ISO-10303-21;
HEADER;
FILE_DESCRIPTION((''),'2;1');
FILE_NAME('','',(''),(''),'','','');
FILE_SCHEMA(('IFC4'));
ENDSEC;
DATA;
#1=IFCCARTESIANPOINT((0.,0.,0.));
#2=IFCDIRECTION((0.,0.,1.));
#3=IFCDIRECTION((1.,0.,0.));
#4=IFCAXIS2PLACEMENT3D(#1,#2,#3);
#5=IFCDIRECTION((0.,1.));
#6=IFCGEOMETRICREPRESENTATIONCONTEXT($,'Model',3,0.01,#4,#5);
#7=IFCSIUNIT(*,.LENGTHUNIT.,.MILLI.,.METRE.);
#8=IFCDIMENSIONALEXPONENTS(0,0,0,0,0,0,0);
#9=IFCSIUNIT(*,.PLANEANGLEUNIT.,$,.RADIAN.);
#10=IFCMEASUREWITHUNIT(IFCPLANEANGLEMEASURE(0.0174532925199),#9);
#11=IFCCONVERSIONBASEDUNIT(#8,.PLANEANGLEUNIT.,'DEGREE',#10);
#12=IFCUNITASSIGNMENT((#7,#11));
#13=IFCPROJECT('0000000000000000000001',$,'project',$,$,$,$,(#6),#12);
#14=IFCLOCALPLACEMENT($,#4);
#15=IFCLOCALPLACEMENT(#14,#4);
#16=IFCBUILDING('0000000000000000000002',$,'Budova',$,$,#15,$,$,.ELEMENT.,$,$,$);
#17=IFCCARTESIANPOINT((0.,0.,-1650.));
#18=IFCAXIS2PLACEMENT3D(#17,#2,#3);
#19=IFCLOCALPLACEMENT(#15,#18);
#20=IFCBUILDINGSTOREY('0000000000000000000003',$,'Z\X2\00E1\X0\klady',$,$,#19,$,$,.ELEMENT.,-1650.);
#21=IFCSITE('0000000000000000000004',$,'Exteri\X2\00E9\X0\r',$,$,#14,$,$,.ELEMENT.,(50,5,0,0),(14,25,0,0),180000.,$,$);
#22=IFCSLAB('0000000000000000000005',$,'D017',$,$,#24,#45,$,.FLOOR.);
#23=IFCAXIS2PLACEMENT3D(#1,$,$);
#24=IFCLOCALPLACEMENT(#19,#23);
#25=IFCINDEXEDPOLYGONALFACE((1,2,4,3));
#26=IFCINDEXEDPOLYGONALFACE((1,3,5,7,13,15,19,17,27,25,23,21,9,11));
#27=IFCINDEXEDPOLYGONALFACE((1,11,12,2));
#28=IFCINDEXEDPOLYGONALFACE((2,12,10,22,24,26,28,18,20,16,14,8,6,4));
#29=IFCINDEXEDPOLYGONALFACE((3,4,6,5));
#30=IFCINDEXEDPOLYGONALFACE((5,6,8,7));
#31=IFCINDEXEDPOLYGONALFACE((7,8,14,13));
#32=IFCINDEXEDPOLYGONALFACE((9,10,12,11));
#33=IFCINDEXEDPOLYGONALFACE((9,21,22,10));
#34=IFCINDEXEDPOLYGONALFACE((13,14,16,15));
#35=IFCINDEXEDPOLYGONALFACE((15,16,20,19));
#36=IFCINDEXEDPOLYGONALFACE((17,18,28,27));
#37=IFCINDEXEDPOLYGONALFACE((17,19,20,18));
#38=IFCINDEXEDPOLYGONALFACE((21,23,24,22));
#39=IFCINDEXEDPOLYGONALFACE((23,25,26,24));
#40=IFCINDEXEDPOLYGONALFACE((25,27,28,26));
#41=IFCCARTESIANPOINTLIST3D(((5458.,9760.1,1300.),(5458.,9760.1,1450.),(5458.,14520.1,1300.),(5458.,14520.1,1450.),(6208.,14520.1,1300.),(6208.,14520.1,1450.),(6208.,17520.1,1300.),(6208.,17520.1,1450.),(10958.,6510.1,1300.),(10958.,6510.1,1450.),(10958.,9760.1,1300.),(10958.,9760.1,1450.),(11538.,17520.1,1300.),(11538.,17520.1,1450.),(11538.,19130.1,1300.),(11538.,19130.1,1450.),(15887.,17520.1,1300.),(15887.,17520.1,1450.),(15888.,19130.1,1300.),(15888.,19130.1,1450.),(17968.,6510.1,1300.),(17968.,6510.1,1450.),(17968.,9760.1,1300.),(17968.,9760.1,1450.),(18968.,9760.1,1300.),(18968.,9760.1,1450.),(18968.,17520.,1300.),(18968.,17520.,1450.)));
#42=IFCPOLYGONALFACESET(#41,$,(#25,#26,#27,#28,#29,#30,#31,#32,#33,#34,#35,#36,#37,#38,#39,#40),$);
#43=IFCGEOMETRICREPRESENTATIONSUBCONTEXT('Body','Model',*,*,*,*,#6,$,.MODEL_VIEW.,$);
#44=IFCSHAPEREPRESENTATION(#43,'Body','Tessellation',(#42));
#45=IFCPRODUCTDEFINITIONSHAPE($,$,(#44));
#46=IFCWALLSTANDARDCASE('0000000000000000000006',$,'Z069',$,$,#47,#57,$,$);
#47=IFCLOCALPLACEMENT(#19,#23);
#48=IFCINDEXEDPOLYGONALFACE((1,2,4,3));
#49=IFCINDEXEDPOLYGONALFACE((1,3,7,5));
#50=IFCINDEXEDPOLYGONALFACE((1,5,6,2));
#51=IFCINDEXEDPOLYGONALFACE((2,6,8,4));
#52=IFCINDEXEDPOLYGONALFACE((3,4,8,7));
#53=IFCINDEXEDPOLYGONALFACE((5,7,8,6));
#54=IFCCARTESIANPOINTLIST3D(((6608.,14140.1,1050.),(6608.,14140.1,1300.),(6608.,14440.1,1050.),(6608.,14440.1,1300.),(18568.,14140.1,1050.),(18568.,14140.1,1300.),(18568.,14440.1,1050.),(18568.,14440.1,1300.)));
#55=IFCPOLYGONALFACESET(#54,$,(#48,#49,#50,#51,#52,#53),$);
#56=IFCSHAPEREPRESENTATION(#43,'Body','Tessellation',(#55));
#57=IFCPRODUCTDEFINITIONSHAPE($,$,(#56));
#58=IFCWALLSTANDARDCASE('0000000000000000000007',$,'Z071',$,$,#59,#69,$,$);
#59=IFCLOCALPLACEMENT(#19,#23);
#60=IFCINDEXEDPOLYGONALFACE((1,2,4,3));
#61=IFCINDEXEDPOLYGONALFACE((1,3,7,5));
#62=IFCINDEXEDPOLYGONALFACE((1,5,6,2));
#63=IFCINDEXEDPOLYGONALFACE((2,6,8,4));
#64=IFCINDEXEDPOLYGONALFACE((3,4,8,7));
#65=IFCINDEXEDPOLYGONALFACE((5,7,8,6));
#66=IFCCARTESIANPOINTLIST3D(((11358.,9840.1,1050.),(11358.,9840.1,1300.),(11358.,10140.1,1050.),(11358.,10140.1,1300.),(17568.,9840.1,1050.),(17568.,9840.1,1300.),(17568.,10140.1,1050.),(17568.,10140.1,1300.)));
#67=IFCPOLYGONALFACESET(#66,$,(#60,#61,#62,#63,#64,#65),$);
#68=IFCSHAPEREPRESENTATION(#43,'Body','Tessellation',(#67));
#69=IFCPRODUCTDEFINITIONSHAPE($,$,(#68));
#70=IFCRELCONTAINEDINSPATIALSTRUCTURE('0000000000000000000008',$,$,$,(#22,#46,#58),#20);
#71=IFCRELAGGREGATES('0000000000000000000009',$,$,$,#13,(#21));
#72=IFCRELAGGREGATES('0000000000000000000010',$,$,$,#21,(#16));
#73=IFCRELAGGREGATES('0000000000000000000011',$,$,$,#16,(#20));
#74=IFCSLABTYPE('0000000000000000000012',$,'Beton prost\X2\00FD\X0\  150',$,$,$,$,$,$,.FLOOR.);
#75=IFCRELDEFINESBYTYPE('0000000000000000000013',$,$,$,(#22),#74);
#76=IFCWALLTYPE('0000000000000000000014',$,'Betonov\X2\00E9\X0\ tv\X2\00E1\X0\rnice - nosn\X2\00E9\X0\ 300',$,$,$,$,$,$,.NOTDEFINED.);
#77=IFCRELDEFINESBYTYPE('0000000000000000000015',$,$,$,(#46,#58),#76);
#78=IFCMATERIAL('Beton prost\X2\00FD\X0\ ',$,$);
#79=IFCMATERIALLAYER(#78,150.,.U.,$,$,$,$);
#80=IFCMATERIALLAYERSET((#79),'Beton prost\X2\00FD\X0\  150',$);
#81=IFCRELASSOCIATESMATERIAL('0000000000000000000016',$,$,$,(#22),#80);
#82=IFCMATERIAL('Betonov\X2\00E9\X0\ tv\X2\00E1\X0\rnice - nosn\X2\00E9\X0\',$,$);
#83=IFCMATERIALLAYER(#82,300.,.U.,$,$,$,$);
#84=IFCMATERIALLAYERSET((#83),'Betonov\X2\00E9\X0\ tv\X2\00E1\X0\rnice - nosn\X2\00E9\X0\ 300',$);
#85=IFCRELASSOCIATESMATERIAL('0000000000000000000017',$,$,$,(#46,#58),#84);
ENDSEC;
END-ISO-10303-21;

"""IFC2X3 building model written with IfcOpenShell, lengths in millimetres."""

from ifc_helpers import new_model, entity, si_unit, converted_unit, direction, frame, origin_with_axes, place, context, subcontext, project, spatial, polyline, outline, extrude, material, layer, layer_set, layer_usage, type_object, element, save


model = new_model("IFC2X3")

# Units and contexts
model_context = context("Model", 3, precision=0.01, world=origin_with_axes(), true_north=direction((0.0, 1.0)))
body_context = subcontext(model_context, "Body", "Model", "MODEL_VIEW")
ifc_project = project(units=[si_unit("LENGTHUNIT", "METRE", prefix="MILLI"), converted_unit("PLANEANGLEUNIT", "DEGREE", entity("IfcPlaneAngleMeasure", 0.0174532925199), si_unit("PLANEANGLEUNIT", "RADIAN"), dimensions=[0, 0, 0, 0, 0, 0, 0])], contexts=[model_context])

# Site, building, storey
site_placement = place(None, origin_with_axes())
site = spatial("IfcSite", under=ifc_project, at=site_placement, Name="Exteriér", CompositionType="ELEMENT", RefLatitude=(50, 5, 0, 0), RefLongitude=(14, 25, 0, 0), RefElevation=180000.0)
building_placement = place(site_placement, origin_with_axes())
building = spatial("IfcBuilding", under=site, at=building_placement, Name="Budova", CompositionType="ELEMENT")
storey_placement = place(building_placement, frame((0.0, 0.0, -1650.0), z_axis=(0.0, 0.0, 1.0), x_axis=(1.0, 0.0, 0.0)))
storey = spatial("IfcBuildingStorey", under=building, at=storey_placement, Name="Základy", CompositionType="ELEMENT", Elevation=-1650.0)

# Slab
ifc_material_1 = material(Name="Beton prostý ")
ifc_layer_1 = layer(ifc_material_1, 150.0, ventilated="UNKNOWN")
ifc_layer_set_1 = layer_set([ifc_layer_1], Name="Beton prostý  150")
ifc_layer_usage_1 = layer_usage(ifc_layer_set_1, "AXIS3", "NEGATIVE", 150.0)
slab_type = type_object("IfcSlabType", Name="Beton prostý  150", PredefinedType="FLOOR")
slab_placement = place(storey_placement, frame((5458.0, 14520.1, 1450.0), z_axis=(0.0, 0.0, 1.0), x_axis=(1.0, 0.0, 0.0)))
element("IfcSlab", 1, at=slab_placement, inside=storey, type_object=slab_type, material=ifc_layer_usage_1, Name="D017", PredefinedType="FLOOR", context=body_context, shape_type="SweptSolid", body=[
    extrude(outline(polyline([(0.0, 0.0), (0.0, -4760.0), (5500.0, -4760.0), (5500.0, -8010.0), (12510.0, -8010.0), (12510.0, -4760.0), (13510.0, -4760.0), (13510.0, 2999.9), (10429.0, 3000.0), (10430.0, 4610.0), (6080.0, 4610.0), (6080.0, 3000.0), (750.0, 3000.0), (750.0, 0.0), (0.0, 0.0)])), frame((0.0, 0.0, -150.0), z_axis=(0.0, 0.0, 1.0), x_axis=(1.0, 0.0, 0.0)), (0.0, 0.0, 1.0), 150.0),
])

# Walls
ifc_material_2 = material(Name="Betonové tvárnice - nosné")
ifc_layer_2 = layer(ifc_material_2, 300.0, ventilated="UNKNOWN")
ifc_layer_set_2 = layer_set([ifc_layer_2], Name="Betonové tvárnice - nosné 300")
wall_type_1 = type_object("IfcWallType", Name="Betonové tvárnice - nosné 300", PredefinedType="NOTDEFINED")
ifc_layer_usage_2 = layer_usage(ifc_layer_set_2, "AXIS2", "POSITIVE", -300.0)
wall_1_placement = place(storey_placement, frame((6608.0, 14440.1, 1050.0), z_axis=(0.0, 0.0, 1.0), x_axis=(1.0, 0.0, 0.0)))
element("IfcWallStandardCase", 2, at=wall_1_placement, inside=storey, type_object=wall_type_1, material=ifc_layer_usage_2, Name="Z069", context=body_context, shape_type="SweptSolid", body=[
    extrude(outline(polyline([(0.0, -300.0), (11960.0, -300.0), (11960.0, 0.0), (0.0, 0.0), (0.0, -300.0)])), origin_with_axes(), (0.0, 0.0, 1.0), 250.0),
])
ifc_layer_usage_3 = layer_usage(ifc_layer_set_2, "AXIS2", "POSITIVE", -300.0)
wall_2_placement = place(storey_placement, frame((11358.0, 10140.1, 1050.0), z_axis=(0.0, 0.0, 1.0), x_axis=(1.0, 0.0, 0.0)))
element("IfcWallStandardCase", 3, at=wall_2_placement, inside=storey, type_object=wall_type_1, material=ifc_layer_usage_3, Name="Z071", context=body_context, shape_type="SweptSolid", body=[
    extrude(outline(polyline([(0.0, -300.0), (6210.0, -300.0), (6210.0, 0.0), (0.0, 0.0), (0.0, -300.0)])), origin_with_axes(), (0.0, 0.0, 1.0), 250.0),
])

save(model, "model.ifc")
